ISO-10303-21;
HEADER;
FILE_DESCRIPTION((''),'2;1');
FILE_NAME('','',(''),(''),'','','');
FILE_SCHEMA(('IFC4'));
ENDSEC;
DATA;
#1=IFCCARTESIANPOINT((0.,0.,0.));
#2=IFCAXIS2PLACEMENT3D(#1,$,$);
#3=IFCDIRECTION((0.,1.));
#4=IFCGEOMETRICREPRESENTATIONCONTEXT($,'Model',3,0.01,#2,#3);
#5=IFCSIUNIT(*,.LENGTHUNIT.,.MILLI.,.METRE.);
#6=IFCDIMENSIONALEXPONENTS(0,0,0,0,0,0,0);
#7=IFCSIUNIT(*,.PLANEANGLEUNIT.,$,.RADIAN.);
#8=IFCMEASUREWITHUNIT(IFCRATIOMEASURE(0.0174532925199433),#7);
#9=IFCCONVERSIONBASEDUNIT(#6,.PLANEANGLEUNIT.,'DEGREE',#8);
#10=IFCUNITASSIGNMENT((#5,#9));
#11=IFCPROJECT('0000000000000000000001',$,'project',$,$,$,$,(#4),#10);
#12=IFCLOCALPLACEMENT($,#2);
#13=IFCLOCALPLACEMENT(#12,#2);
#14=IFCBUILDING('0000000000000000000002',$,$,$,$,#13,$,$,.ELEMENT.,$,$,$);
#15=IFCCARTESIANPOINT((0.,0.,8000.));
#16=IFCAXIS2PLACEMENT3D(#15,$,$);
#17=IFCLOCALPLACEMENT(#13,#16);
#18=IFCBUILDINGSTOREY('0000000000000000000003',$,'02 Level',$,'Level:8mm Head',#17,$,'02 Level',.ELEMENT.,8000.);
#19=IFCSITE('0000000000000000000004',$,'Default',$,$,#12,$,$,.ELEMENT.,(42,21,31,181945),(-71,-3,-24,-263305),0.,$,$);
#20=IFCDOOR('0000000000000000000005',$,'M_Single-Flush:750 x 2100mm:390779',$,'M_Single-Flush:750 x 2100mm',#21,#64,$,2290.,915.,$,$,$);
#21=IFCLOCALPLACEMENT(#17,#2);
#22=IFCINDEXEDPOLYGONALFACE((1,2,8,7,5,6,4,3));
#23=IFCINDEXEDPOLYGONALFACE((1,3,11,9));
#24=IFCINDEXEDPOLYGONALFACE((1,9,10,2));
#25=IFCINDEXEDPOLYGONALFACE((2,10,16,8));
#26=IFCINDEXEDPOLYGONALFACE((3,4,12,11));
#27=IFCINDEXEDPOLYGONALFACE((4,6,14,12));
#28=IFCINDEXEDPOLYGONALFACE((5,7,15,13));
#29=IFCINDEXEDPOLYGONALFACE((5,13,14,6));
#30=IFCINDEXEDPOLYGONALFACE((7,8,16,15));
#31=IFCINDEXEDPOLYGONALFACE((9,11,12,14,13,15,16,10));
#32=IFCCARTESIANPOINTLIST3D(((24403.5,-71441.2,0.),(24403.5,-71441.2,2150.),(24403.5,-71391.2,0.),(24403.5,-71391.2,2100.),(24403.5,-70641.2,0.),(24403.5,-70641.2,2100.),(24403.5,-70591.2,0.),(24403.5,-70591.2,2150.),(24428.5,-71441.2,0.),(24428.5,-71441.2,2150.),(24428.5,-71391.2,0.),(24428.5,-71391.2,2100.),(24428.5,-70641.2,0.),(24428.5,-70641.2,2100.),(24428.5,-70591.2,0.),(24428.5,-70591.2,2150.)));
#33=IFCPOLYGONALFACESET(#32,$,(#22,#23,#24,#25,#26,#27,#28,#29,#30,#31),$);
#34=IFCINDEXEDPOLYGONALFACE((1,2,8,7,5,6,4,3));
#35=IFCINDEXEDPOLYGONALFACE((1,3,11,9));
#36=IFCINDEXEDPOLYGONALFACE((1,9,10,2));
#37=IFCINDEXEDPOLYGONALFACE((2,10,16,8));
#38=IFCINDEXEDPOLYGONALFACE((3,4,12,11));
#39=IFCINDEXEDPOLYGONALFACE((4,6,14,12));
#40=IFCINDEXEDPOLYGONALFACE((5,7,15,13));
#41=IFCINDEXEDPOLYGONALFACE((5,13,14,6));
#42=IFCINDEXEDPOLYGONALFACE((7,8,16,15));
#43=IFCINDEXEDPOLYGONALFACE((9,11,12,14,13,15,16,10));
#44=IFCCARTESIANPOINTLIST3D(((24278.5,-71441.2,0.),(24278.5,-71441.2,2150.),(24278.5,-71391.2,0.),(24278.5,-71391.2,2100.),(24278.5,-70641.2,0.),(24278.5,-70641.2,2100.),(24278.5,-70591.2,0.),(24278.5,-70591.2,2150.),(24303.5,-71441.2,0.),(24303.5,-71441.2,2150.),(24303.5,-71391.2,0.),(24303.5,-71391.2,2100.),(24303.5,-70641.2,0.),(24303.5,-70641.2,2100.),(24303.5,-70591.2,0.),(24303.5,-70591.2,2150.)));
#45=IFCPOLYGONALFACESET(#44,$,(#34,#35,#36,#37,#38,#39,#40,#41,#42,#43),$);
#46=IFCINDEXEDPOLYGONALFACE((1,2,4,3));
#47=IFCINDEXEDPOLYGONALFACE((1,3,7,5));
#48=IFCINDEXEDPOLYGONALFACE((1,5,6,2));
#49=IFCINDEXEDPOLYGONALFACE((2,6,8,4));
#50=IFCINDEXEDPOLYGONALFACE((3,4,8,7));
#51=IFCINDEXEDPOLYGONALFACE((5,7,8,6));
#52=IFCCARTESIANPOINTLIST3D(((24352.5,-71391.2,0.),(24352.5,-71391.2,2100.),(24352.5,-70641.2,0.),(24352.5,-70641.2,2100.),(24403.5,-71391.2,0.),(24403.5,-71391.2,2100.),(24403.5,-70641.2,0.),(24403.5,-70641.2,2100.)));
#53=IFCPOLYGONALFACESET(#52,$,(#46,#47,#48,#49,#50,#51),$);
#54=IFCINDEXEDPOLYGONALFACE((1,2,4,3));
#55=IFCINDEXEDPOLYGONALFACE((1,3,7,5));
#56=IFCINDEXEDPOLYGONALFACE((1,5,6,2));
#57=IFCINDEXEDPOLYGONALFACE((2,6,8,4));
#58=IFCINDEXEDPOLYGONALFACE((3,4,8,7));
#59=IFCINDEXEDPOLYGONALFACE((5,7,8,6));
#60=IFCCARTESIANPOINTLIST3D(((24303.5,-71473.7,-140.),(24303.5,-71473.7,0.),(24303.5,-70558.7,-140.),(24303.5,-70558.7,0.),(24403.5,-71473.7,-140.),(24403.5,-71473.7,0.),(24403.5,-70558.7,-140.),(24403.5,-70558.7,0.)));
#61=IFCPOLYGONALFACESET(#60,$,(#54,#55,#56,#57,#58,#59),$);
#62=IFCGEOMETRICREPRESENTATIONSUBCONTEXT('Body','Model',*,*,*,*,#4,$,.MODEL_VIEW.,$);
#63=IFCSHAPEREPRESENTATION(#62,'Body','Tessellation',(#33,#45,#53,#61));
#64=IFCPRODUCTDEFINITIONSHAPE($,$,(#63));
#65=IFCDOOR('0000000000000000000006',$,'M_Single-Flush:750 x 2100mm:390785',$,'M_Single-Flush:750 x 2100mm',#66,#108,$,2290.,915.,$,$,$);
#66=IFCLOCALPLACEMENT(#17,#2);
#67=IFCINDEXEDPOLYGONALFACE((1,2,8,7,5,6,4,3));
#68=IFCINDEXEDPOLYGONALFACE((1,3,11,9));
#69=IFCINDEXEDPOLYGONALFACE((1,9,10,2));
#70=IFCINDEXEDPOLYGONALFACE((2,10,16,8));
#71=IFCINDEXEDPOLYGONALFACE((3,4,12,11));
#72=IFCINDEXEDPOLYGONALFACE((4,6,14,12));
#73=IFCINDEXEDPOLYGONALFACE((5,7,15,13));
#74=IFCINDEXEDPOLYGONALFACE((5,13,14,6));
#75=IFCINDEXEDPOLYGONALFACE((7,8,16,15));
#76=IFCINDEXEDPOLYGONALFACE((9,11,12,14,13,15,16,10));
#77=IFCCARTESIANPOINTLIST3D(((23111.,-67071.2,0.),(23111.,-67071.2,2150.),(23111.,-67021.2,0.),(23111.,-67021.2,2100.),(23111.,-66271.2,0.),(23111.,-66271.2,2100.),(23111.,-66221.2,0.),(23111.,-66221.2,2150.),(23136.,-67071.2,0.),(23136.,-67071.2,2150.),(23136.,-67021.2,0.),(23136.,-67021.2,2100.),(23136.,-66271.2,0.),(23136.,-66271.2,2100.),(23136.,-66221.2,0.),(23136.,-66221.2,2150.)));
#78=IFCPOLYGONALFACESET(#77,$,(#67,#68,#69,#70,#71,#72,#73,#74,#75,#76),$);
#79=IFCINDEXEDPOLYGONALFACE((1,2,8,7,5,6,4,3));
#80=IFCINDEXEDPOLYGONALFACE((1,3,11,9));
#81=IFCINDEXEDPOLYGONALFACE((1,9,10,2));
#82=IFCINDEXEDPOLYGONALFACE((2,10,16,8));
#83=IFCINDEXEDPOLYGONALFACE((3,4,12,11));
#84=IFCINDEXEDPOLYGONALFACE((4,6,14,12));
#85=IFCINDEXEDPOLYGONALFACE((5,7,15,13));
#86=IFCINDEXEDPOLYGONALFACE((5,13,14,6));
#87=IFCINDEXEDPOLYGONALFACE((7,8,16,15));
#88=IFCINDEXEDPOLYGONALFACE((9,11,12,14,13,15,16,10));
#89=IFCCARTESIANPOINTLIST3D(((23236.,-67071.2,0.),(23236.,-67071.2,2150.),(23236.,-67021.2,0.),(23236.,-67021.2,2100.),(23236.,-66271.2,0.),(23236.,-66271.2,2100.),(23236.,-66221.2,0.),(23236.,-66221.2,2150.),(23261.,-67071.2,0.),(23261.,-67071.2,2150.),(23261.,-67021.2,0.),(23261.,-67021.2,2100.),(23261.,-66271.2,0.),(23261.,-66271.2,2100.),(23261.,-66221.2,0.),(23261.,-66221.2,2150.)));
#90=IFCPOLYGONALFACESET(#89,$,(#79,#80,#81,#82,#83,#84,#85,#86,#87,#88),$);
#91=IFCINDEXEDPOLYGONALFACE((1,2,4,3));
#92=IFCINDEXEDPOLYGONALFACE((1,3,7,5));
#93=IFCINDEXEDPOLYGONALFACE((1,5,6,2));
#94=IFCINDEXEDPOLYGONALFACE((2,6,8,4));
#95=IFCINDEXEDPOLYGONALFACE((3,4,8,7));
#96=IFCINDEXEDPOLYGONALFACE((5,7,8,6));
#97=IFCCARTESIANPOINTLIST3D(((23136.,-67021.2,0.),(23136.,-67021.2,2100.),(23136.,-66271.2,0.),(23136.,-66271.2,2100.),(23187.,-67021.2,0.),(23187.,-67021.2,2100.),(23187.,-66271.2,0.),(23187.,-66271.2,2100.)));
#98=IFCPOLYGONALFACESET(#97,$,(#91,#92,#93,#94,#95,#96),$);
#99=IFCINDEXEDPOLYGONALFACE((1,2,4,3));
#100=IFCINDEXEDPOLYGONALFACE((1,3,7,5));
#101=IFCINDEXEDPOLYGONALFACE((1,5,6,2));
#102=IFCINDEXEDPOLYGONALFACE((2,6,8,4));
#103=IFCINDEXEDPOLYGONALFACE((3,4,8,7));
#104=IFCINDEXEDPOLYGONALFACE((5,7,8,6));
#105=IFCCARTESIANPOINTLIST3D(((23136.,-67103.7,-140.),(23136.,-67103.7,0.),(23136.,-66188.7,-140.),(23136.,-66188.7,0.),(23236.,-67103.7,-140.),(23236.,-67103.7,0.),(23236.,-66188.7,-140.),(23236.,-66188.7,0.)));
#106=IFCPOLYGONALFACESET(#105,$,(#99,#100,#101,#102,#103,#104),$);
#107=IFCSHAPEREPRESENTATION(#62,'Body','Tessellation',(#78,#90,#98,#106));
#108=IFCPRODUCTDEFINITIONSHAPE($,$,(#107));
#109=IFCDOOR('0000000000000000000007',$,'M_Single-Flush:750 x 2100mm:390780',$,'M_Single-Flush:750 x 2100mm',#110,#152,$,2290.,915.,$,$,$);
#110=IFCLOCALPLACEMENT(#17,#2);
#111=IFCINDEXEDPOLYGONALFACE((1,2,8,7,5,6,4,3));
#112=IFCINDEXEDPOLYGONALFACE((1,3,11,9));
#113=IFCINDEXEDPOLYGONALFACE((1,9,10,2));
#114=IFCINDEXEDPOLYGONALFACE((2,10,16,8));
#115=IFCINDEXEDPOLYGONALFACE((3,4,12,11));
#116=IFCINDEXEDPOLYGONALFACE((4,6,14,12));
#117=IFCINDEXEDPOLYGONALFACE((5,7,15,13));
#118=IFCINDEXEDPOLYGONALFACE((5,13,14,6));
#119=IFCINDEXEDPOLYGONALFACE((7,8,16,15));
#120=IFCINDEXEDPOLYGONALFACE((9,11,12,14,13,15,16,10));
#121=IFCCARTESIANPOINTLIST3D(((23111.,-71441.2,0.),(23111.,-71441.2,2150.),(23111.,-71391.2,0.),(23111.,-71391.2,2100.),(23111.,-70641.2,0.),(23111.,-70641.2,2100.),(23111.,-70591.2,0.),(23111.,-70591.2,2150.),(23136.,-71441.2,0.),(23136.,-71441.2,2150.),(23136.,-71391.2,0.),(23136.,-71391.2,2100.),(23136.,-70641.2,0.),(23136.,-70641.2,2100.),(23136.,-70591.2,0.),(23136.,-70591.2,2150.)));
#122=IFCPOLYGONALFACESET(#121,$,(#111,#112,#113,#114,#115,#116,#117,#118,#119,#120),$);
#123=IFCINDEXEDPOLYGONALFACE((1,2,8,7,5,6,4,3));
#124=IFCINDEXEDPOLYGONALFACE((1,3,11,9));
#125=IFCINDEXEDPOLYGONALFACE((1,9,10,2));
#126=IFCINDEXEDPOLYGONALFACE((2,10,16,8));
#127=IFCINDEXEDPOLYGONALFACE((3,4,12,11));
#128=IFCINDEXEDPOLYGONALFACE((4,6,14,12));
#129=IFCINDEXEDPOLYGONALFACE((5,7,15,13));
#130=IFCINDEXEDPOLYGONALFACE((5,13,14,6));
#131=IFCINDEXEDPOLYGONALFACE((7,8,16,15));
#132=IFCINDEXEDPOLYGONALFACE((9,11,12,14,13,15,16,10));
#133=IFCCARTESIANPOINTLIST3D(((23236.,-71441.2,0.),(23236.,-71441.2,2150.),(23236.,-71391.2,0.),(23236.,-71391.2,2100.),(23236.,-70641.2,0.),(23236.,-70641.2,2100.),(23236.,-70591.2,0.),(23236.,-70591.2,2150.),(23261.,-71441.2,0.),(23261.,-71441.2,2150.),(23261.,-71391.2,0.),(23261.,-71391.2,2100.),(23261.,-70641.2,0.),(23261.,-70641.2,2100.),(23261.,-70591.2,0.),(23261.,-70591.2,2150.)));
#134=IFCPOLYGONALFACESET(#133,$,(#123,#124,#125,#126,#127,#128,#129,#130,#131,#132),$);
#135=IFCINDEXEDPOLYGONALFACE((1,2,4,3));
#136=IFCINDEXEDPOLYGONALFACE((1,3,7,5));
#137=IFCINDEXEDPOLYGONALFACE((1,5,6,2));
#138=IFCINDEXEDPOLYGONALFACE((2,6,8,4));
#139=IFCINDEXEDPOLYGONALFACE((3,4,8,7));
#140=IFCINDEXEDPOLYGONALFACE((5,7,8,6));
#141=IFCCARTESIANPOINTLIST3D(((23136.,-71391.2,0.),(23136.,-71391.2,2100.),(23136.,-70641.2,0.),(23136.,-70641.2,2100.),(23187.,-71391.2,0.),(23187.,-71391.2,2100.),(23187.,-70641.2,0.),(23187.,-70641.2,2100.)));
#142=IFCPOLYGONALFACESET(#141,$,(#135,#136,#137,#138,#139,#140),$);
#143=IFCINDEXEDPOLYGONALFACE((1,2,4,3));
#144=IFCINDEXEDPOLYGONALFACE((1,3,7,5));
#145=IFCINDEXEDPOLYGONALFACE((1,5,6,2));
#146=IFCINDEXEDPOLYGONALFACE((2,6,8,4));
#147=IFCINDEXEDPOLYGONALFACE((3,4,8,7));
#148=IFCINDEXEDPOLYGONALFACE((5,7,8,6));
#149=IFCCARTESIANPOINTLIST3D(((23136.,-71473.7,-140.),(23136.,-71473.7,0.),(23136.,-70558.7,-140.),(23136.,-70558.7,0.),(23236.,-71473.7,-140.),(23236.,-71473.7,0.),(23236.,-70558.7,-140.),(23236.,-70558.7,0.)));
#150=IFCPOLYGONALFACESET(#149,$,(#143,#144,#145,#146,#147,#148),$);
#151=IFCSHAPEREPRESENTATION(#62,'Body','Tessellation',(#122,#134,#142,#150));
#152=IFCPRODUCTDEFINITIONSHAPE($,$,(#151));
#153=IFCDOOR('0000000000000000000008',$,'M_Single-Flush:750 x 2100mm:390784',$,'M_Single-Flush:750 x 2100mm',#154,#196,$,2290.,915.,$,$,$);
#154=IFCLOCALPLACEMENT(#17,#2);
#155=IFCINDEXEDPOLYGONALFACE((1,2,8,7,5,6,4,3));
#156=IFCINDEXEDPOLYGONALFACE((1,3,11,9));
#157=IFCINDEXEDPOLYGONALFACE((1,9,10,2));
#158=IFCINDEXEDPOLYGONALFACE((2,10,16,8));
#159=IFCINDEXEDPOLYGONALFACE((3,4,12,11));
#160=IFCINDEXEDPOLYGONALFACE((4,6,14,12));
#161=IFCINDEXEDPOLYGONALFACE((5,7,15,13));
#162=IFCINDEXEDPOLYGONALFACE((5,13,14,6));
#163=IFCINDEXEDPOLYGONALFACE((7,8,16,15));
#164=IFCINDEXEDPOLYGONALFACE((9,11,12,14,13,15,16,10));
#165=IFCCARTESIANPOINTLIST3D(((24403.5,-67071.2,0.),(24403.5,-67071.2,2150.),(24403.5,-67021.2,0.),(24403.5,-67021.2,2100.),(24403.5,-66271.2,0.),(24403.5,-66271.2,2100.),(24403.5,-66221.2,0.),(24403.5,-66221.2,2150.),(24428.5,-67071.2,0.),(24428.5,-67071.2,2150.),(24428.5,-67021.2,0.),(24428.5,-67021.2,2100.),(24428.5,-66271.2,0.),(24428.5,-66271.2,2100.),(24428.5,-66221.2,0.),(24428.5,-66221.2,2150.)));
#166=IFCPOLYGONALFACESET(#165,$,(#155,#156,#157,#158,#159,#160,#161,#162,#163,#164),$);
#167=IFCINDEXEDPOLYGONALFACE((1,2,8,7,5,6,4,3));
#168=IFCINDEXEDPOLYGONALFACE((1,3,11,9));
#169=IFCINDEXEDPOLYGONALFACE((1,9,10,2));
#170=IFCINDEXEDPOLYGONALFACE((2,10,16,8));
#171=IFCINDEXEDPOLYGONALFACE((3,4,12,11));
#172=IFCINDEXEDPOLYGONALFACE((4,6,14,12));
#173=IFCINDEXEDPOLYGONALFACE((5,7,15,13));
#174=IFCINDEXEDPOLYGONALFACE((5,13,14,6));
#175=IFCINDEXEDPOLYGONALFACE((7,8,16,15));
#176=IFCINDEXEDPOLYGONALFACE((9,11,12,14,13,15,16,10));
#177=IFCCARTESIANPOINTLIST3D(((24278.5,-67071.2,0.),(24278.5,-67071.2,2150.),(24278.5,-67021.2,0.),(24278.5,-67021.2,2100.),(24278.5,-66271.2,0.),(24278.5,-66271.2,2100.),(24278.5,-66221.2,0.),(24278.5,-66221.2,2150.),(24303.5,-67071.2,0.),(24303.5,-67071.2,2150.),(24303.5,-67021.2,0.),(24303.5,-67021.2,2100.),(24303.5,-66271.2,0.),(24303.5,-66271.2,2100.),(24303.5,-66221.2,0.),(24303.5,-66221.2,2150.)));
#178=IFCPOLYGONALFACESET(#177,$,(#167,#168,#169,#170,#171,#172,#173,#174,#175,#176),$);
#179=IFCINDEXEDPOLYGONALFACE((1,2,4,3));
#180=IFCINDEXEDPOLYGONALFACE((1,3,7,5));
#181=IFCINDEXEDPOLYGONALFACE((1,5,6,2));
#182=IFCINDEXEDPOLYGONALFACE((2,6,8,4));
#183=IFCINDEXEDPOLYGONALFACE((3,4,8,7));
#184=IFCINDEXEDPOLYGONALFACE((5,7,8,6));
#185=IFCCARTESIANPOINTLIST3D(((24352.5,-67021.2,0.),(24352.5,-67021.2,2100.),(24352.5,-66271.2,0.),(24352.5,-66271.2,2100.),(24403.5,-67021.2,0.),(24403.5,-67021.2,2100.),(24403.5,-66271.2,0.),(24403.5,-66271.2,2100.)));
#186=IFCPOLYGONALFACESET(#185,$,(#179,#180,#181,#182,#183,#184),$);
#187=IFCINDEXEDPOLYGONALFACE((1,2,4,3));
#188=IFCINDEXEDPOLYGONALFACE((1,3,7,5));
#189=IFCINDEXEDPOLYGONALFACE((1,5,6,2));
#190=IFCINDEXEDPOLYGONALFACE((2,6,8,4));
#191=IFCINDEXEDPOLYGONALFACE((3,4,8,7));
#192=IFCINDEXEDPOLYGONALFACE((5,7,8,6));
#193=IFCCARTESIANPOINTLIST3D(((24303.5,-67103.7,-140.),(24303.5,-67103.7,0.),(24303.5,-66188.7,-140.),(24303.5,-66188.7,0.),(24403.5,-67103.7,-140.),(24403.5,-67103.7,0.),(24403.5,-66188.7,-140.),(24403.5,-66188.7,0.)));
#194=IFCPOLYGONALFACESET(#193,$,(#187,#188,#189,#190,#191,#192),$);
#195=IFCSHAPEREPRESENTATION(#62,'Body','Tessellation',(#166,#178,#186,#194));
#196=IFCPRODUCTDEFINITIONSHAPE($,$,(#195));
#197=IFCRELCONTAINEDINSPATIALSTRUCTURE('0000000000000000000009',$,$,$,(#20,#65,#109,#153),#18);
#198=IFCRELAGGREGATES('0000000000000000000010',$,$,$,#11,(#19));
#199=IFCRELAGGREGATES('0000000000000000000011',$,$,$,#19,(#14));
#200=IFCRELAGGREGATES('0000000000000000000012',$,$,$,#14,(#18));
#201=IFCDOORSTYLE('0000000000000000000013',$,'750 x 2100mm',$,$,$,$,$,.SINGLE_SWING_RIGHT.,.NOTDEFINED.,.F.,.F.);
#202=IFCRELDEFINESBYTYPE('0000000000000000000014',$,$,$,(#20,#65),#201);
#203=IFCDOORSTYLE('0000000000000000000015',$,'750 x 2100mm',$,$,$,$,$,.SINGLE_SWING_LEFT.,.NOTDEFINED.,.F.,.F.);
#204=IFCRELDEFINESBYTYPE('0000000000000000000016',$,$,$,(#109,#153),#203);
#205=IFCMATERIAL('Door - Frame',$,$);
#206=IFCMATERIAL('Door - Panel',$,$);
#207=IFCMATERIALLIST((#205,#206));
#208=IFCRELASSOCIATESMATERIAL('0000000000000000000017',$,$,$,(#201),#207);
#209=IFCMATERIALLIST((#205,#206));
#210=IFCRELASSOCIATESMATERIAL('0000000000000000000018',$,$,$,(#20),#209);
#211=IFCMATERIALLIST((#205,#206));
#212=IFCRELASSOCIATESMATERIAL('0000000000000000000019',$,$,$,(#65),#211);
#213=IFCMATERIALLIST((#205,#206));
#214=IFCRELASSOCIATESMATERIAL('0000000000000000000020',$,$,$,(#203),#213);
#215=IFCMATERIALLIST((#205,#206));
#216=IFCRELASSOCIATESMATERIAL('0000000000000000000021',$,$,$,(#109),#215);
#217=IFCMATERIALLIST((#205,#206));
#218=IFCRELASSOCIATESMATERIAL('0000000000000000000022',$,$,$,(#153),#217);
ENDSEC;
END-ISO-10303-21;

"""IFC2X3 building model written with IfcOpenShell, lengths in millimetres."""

from ifc_helpers import new_model, entity, si_unit, converted_unit, direction, frame, frame_2d, origin, origin_2d_with_axis, place, context, subcontext, project, spatial, polyline, rectangle, outline, extrude, source, transform, mapped, material, material_list, type_object, type_shapes, element, save


model = new_model("IFC2X3")

# Units and contexts
model_context = context("Model", 3, precision=0.01, world=origin(), true_north=direction((0.0, 1.0)))
body_context = subcontext(model_context, "Body", "Model", "MODEL_VIEW")
ifc_project = project(units=[si_unit("LENGTHUNIT", "METRE", prefix="MILLI"), converted_unit("PLANEANGLEUNIT", "DEGREE", entity("IfcRatioMeasure", 0.0174532925199433), si_unit("PLANEANGLEUNIT", "RADIAN"), dimensions=[0, 0, 0, 0, 0, 0, 0])], contexts=[model_context])

# Site, building, storey
site_placement = place(None, origin())
site = spatial("IfcSite", under=ifc_project, at=site_placement, Name="Default", CompositionType="ELEMENT", RefLatitude=(42, 21, 31, 181945), RefLongitude=(-71, -3, -24, -263305), RefElevation=0.0)
building_placement = place(site_placement, origin())
building = spatial("IfcBuilding", under=site, at=building_placement, CompositionType="ELEMENT")
storey_placement = place(building_placement, frame((0.0, 0.0, 8000.0)))
storey = spatial("IfcBuildingStorey", under=building, at=storey_placement, Name="02 Level", ObjectType="Level:8mm Head", LongName="02 Level", CompositionType="ELEMENT", Elevation=8000.0)

# Shared definitions
ifc_material_1 = material(Name="Door - Frame")
ifc_material_2 = material(Name="Door - Panel")

# Doors
ifc_material_list_1 = material_list([ifc_material_1, ifc_material_2])
ifc_material_list_2 = material_list([ifc_material_1, ifc_material_2])
door_style_1 = type_object("IfcDoorStyle", Name="750 x 2100mm", ConstructionType="NOTDEFINED", OperationType="SINGLE_SWING_RIGHT", ParameterTakesPrecedence=False, Sizeable=False, material=ifc_material_list_2)
shared_shape_1 = source(origin(), body_context, "Body", "SweptSolid", [
    extrude(outline(polyline([(-425.0, -1087.5), (425.0, -1087.5), (425.0, 1062.5), (375.0, 1062.5), (375.0, -1037.5), (-375.0, -1037.5), (-375.0, 1062.5), (-425.0, 1062.5), (-425.0, -1087.5)])), frame((375.0, 100.0, 1202.5), z_axis=(0.0, 1.0, 0.0), x_axis=(1.0, 0.0, 0.0)), (0.0, 0.0, 1.0), 25.0),
    extrude(outline(polyline([(-1087.5, -425.0), (1062.5, -425.0), (1062.5, -375.0), (-1037.5, -375.0), (-1037.5, 375.0), (1062.5, 375.0), (1062.5, 425.0), (-1087.5, 425.0), (-1087.5, -425.0)])), frame((375.0, -25.0, 1202.5), z_axis=(0.0, 1.0, 0.0), x_axis=(0.0, 0.0, -1.0)), (0.0, 0.0, 1.0), 25.0),
    extrude(rectangle(XDim=51.0, YDim=750.0, at=origin_2d_with_axis()), frame((375.0, 74.5, 140.0), z_axis=(0.0, 0.0, 1.0), x_axis=(0.0, 1.0, 0.0)), (0.0, 0.0, 1.0), 2100.0),
    extrude(rectangle(XDim=915.0, YDim=100.0, at=frame_2d((0.0, 0.0), x_axis=(1.0, 0.0))), frame((375.0, 50.0, 0.0), z_axis=(0.0, 0.0, 1.0), x_axis=(-1.0, 0.0, 0.0)), (0.0, 0.0, 1.0), 140.0),
])
type_shapes(door_style_1, [shared_shape_1])
door_1_placement = place(storey_placement, frame((24303.5, -70641.2, -140.0), z_axis=(0.0, 0.0, 1.0), x_axis=(0.0, -1.0, 0.0)))
element("IfcDoor", 1, at=door_1_placement, inside=storey, type_object=door_style_1, material=ifc_material_list_1, Name="M_Single-Flush:750 x 2100mm:390779", ObjectType="M_Single-Flush:750 x 2100mm", OverallHeight=2290.0, OverallWidth=915.0, context=body_context, shape_type="MappedRepresentation", body=[
    mapped(shared_shape_1, transform((0.0, 0.0, 0.0), scale=1.0)),
])
ifc_material_list_3 = material_list([ifc_material_1, ifc_material_2])
door_2_placement = place(storey_placement, frame((23236.0, -67021.2, -140.0), z_axis=(0.0, 0.0, 1.0), x_axis=(0.0, 1.0, 0.0)))
element("IfcDoor", 2, at=door_2_placement, inside=storey, type_object=door_style_1, material=ifc_material_list_3, Name="M_Single-Flush:750 x 2100mm:390785", ObjectType="M_Single-Flush:750 x 2100mm", OverallHeight=2290.0, OverallWidth=915.0, context=body_context, shape_type="MappedRepresentation", body=[
    mapped(shared_shape_1, transform((0.0, 0.0, 0.0), scale=1.0)),
])
ifc_material_list_4 = material_list([ifc_material_1, ifc_material_2])
ifc_material_list_5 = material_list([ifc_material_1, ifc_material_2])
door_style_2 = type_object("IfcDoorStyle", Name="750 x 2100mm", ConstructionType="NOTDEFINED", OperationType="SINGLE_SWING_LEFT", ParameterTakesPrecedence=False, Sizeable=False, material=ifc_material_list_5)
shared_shape_2 = source(origin(), body_context, "Body", "SweptSolid", [
    extrude(outline(polyline([(-425.0, -1087.5), (425.0, -1087.5), (425.0, 1062.5), (375.0, 1062.5), (375.0, -1037.5), (-375.0, -1037.5), (-375.0, 1062.5), (-425.0, 1062.5), (-425.0, -1087.5)])), frame((375.0, 125.0, 1202.5), z_axis=(0.0, -1.0, 0.0), x_axis=(-1.0, 0.0, 0.0)), (0.0, 0.0, 1.0), 25.0),
    extrude(outline(polyline([(-1087.5, -425.0), (1062.5, -425.0), (1062.5, -375.0), (-1037.5, -375.0), (-1037.5, 375.0), (1062.5, 375.0), (1062.5, 425.0), (-1087.5, 425.0), (-1087.5, -425.0)])), frame((375.0, 0.0, 1202.5), z_axis=(0.0, -1.0, 0.0), x_axis=(0.0, 0.0, -1.0)), (0.0, 0.0, 1.0), 25.0),
    extrude(rectangle(XDim=750.0, YDim=51.0, at=origin_2d_with_axis()), frame((375.0, 74.5, 140.0)), (0.0, 0.0, 1.0), 2100.0),
    extrude(rectangle(XDim=100.0, YDim=915.0, at=origin_2d_with_axis()), frame((375.0, 50.0, 0.0), z_axis=(0.0, 0.0, 1.0), x_axis=(0.0, -1.0, 0.0)), (0.0, 0.0, 1.0), 140.0),
])
type_shapes(door_style_2, [shared_shape_2])
door_3_placement = place(storey_placement, frame((23236.0, -71391.2, -140.0), z_axis=(0.0, 0.0, 1.0), x_axis=(0.0, 1.0, 0.0)))
element("IfcDoor", 3, at=door_3_placement, inside=storey, type_object=door_style_2, material=ifc_material_list_4, Name="M_Single-Flush:750 x 2100mm:390780", ObjectType="M_Single-Flush:750 x 2100mm", OverallHeight=2290.0, OverallWidth=915.0, context=body_context, shape_type="MappedRepresentation", body=[
    mapped(shared_shape_2, transform((0.0, 0.0, 0.0), scale=1.0)),
])
ifc_material_list_6 = material_list([ifc_material_1, ifc_material_2])
door_4_placement = place(storey_placement, frame((24303.5, -66271.2, -140.0), z_axis=(0.0, 0.0, 1.0), x_axis=(0.0, -1.0, 0.0)))
element("IfcDoor", 4, at=door_4_placement, inside=storey, type_object=door_style_2, material=ifc_material_list_6, Name="M_Single-Flush:750 x 2100mm:390784", ObjectType="M_Single-Flush:750 x 2100mm", OverallHeight=2290.0, OverallWidth=915.0, context=body_context, shape_type="MappedRepresentation", body=[
    mapped(shared_shape_2, transform((0.0, 0.0, 0.0), scale=1.0)),
])

save(model, "model.ifc")
